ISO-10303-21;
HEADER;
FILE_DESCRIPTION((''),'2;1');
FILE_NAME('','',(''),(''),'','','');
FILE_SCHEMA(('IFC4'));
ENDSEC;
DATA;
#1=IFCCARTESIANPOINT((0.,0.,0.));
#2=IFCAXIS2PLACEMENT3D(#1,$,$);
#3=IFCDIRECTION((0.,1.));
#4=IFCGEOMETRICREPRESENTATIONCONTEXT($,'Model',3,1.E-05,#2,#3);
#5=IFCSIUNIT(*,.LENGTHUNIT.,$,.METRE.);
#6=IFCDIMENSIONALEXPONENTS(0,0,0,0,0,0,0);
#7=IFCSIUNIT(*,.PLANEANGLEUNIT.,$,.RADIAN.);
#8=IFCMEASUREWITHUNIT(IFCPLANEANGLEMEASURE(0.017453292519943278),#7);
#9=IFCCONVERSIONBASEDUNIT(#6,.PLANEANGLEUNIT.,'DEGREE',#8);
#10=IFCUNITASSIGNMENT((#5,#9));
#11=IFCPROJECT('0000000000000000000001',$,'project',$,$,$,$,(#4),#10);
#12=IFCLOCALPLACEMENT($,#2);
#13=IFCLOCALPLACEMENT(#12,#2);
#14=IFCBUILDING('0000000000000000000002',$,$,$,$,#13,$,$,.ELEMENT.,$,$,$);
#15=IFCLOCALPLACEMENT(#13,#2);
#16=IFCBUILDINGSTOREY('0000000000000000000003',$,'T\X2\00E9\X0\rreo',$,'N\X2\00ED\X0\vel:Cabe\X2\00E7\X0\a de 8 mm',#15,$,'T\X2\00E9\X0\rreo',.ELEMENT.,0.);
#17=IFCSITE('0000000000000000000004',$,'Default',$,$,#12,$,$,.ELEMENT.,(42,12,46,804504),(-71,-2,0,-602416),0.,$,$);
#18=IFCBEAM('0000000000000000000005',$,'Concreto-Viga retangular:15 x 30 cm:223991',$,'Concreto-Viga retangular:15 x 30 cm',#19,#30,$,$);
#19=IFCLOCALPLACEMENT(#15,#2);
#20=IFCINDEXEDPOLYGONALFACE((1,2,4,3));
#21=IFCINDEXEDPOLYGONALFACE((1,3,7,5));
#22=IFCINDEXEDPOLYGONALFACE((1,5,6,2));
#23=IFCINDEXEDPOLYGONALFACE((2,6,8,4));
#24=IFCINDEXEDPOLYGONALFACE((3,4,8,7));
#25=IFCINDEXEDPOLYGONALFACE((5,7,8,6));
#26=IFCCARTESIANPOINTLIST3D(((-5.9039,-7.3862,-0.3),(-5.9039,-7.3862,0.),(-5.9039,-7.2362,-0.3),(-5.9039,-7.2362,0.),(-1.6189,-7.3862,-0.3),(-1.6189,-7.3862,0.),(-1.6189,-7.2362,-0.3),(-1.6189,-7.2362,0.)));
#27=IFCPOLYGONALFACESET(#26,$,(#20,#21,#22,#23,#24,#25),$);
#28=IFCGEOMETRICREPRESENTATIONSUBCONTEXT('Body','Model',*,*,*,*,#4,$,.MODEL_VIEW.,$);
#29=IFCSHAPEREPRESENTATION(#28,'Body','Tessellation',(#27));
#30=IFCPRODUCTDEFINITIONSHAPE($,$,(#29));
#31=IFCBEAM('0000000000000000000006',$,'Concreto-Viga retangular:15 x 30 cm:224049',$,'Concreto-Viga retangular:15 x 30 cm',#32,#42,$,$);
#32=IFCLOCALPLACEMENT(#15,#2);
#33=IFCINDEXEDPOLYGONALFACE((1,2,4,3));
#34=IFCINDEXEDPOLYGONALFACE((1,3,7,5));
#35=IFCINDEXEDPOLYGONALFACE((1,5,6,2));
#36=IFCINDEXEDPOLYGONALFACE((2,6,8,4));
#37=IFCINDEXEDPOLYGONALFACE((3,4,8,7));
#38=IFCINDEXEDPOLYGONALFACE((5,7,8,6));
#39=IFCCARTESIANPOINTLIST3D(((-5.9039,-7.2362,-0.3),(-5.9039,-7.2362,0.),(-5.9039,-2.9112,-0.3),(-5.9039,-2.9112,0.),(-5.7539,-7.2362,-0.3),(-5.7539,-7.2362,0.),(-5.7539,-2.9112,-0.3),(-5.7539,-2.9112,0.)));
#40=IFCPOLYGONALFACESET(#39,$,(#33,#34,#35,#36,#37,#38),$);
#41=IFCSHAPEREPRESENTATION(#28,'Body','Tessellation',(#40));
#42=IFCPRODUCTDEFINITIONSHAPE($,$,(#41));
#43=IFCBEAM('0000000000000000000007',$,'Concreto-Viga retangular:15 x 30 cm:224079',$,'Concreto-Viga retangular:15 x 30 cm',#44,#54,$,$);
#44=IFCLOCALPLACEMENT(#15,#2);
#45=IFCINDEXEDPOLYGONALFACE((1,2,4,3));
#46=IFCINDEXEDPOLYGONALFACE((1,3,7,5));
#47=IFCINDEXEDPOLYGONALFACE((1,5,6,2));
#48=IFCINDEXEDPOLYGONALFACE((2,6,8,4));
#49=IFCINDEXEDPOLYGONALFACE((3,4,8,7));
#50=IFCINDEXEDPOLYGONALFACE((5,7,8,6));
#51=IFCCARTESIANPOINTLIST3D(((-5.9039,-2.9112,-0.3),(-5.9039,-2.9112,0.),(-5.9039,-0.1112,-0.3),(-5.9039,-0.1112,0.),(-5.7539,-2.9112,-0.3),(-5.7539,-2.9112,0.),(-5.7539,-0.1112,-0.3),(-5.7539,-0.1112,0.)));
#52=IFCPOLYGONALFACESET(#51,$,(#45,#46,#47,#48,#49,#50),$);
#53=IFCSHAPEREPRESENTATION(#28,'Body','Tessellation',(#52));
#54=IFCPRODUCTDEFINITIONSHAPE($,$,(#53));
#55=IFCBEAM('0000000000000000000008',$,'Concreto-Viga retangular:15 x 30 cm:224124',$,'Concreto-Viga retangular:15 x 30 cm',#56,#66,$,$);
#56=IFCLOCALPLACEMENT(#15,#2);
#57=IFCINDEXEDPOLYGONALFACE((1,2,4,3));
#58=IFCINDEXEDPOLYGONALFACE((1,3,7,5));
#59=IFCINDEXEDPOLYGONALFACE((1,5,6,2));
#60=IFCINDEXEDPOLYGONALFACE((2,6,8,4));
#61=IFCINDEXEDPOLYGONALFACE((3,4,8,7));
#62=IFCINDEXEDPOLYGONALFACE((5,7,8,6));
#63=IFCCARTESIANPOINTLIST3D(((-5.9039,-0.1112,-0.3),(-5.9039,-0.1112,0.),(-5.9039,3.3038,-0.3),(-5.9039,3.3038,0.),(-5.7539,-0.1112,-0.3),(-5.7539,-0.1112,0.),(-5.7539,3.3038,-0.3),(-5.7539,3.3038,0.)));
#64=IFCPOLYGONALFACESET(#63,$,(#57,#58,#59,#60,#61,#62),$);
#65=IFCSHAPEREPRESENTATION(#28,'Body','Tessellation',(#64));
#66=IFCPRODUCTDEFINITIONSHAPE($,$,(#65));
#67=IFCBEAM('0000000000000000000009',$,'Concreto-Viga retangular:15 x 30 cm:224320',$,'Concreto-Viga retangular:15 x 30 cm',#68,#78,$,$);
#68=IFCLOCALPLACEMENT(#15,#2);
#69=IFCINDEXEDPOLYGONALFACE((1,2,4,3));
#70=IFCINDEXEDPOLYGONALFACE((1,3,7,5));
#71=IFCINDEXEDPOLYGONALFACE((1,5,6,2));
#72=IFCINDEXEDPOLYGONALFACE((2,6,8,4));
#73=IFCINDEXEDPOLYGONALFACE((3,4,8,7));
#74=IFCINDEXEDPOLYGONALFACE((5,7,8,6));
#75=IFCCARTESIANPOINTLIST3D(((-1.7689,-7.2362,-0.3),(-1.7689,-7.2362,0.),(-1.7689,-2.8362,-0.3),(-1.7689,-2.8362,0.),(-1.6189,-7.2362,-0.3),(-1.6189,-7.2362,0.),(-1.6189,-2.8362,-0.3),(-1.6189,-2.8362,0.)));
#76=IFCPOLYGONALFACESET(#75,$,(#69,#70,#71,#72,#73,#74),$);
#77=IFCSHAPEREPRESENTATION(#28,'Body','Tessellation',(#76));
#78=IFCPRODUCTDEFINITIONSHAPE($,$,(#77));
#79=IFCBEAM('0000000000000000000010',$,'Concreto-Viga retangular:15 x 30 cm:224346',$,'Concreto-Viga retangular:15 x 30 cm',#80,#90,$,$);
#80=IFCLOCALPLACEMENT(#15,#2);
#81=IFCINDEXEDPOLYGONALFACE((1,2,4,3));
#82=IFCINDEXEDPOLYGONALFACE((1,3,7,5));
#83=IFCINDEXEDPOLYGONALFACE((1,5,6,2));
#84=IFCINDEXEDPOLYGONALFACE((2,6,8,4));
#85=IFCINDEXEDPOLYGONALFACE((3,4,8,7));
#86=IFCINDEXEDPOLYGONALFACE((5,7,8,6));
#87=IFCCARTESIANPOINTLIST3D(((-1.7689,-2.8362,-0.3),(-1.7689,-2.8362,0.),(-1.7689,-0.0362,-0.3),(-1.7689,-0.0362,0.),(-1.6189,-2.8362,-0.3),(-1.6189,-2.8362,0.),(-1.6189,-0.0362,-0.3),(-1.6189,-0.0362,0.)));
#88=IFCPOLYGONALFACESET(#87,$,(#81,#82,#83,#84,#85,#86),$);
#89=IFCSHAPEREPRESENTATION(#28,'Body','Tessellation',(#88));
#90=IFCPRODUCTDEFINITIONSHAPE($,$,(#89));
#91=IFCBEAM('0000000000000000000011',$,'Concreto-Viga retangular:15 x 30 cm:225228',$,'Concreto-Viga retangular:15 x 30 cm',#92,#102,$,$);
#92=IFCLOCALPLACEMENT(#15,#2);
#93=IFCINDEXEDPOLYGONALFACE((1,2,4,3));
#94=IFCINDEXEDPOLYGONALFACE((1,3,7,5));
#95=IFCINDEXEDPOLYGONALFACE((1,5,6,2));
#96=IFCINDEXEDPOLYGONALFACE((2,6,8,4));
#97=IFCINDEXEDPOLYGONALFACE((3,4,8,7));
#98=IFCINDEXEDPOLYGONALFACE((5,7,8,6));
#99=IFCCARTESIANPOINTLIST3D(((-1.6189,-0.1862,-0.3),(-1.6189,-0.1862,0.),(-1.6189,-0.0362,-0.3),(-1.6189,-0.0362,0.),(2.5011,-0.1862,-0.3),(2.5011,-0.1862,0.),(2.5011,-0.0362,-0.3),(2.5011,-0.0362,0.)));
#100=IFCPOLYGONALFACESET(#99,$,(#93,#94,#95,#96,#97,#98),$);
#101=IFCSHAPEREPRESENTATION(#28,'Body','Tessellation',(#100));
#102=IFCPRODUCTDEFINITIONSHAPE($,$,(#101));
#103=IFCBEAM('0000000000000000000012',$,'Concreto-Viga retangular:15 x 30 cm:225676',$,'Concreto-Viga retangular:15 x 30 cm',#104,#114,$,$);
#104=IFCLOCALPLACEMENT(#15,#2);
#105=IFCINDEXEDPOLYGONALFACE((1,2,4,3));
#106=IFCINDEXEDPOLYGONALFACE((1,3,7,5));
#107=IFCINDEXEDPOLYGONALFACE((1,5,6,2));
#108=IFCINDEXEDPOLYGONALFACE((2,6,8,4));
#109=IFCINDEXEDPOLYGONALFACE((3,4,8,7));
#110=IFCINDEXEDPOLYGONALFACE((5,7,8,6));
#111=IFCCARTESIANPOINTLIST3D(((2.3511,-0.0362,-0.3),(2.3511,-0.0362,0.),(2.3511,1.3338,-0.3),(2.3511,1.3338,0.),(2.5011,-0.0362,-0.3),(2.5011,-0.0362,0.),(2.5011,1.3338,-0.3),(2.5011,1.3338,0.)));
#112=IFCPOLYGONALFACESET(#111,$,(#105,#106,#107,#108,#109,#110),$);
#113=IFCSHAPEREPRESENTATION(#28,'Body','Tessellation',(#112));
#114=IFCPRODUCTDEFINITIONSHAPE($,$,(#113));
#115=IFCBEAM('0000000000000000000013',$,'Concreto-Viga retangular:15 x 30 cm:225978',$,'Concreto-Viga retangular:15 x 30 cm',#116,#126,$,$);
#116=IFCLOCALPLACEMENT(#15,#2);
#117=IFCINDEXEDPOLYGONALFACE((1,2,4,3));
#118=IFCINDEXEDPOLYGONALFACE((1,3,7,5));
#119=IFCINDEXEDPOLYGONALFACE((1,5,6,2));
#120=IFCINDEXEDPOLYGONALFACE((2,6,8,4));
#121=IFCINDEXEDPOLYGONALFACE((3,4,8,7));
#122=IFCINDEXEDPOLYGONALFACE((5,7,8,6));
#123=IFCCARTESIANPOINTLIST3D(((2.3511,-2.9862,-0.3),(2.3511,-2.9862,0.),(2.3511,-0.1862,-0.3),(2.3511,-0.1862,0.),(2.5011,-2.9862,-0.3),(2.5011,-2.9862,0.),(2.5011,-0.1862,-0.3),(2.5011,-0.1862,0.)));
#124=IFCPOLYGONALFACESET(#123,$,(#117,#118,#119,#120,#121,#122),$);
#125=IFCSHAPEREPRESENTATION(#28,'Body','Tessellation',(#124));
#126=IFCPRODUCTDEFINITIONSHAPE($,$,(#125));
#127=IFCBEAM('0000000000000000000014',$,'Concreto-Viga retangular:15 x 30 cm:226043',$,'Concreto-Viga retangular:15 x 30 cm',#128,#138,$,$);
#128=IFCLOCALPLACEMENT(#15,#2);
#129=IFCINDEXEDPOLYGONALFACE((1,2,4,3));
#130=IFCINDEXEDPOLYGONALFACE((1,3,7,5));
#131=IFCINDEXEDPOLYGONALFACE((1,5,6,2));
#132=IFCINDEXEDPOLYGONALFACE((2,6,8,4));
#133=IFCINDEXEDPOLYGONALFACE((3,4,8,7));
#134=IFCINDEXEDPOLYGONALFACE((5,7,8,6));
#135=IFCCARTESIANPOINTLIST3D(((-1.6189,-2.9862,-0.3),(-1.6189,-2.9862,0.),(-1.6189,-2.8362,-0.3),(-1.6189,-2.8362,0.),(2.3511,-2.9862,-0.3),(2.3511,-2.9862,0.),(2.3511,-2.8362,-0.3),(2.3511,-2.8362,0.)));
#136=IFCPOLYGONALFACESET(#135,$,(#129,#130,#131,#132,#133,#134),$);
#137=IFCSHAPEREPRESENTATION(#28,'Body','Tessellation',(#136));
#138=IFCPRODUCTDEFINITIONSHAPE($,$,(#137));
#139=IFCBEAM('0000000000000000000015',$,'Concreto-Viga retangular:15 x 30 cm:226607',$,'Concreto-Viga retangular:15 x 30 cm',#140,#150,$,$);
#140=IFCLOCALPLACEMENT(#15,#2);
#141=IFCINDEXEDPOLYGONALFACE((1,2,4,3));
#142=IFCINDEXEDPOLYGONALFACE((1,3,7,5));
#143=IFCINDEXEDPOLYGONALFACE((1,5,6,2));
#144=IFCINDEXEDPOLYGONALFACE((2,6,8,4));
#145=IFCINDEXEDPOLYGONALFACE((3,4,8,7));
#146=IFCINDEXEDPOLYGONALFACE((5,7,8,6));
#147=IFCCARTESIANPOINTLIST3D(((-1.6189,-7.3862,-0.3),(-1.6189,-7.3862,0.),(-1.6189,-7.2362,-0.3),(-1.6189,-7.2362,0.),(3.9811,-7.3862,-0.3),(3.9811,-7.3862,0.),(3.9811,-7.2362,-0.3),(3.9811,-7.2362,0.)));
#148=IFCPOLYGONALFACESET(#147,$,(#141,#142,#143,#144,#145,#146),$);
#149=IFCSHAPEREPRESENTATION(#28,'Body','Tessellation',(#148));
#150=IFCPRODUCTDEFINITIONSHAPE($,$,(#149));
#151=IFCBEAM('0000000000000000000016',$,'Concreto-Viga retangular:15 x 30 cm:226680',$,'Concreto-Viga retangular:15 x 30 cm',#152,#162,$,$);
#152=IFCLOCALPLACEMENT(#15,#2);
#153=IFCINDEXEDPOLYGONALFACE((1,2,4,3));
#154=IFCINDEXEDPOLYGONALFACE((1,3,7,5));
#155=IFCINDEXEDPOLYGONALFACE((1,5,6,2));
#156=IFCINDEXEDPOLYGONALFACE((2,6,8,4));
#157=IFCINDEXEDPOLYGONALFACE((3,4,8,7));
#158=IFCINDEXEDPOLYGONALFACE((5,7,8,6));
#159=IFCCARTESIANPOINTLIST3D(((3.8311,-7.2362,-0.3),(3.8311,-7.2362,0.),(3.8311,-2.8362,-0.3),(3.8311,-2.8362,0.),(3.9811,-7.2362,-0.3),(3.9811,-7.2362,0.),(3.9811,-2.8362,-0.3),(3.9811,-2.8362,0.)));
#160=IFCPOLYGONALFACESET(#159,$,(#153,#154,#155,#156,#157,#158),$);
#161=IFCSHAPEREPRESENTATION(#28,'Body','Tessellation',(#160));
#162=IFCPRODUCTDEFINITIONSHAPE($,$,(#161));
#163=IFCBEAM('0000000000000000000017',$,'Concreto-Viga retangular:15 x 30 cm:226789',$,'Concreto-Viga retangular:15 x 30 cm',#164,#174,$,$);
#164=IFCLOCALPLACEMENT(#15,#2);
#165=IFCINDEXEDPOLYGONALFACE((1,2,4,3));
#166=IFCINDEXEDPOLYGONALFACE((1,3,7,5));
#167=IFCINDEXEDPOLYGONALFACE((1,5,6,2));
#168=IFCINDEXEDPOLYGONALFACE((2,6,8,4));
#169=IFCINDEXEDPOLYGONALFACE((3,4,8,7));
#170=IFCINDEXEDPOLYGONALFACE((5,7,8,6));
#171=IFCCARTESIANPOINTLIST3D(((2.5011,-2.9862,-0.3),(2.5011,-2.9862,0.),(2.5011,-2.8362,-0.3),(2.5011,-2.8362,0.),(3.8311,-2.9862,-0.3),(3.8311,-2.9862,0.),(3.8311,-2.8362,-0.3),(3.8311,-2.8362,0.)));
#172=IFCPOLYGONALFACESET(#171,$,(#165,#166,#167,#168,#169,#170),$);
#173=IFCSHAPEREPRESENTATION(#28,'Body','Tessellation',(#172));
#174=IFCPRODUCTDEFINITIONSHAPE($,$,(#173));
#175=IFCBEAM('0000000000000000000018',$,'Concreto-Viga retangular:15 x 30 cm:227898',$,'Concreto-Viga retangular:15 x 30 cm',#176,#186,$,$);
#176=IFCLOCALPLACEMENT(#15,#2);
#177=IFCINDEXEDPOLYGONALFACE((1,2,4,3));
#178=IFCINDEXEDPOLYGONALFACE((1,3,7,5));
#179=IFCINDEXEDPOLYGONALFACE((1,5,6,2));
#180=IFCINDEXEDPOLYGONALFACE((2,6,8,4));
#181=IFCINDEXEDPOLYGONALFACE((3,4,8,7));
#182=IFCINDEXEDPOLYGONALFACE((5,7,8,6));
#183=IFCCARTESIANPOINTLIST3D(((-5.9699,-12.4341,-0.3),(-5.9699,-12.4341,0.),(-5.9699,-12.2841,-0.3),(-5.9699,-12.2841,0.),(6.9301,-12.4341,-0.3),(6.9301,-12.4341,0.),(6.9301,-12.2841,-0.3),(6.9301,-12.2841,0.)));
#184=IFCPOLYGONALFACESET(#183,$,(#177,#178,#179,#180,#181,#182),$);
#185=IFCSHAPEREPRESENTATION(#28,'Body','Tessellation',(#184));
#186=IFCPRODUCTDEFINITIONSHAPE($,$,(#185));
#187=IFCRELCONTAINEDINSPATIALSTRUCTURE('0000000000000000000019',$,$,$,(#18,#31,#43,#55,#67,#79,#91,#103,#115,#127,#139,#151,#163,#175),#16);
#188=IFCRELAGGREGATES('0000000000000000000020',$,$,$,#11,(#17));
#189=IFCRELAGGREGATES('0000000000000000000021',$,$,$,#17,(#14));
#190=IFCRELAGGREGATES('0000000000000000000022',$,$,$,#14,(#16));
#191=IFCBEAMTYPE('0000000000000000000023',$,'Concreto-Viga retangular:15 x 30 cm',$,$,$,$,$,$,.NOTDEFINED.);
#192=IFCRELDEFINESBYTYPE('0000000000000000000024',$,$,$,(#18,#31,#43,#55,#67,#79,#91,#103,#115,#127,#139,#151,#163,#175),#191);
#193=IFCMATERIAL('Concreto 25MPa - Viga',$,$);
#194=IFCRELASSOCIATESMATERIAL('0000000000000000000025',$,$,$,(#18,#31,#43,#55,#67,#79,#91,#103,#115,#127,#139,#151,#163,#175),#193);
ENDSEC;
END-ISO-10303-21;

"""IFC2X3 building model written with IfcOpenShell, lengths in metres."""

from ifc_helpers import new_model, entity, si_unit, converted_unit, direction, frame, frame_2d, origin, place, context, subcontext, project, spatial, rectangle, extrude, material, type_object, element, save


model = new_model("IFC2X3")

# Units and contexts
model_context = context("Model", 3, precision=1e-05, world=origin(), true_north=direction((0.0, 1.0)))
body_context = subcontext(model_context, "Body", "Model", "MODEL_VIEW")
ifc_project = project(units=[si_unit("LENGTHUNIT", "METRE"), converted_unit("PLANEANGLEUNIT", "DEGREE", entity("IfcPlaneAngleMeasure", 0.017453292519943278), si_unit("PLANEANGLEUNIT", "RADIAN"), dimensions=[0, 0, 0, 0, 0, 0, 0])], contexts=[model_context])

# Site, building, storey
site_placement = place(None, origin())
site = spatial("IfcSite", under=ifc_project, at=site_placement, Name="Default", CompositionType="ELEMENT", RefLatitude=(42, 12, 46, 804504), RefLongitude=(-71, -2, 0, -602416), RefElevation=0.0)
building_placement = place(site_placement, origin())
building = spatial("IfcBuilding", under=site, at=building_placement, CompositionType="ELEMENT")
storey_placement = place(building_placement, origin())
storey = spatial("IfcBuildingStorey", under=building, at=storey_placement, Name="Térreo", ObjectType="Nível:Cabeça de 8 mm", LongName="Térreo", CompositionType="ELEMENT", Elevation=0.0)

# Beams
ifc_material_1 = material(Name="Concreto 25MPa - Viga")
beam_type = type_object("IfcBeamType", Name="Concreto-Viga retangular:15 x 30 cm", PredefinedType="NOTDEFINED")
beam_1_placement = place(storey_placement, frame((-5.8289, -7.3112, 0.0)))
element("IfcBeam", 1, at=beam_1_placement, inside=storey, type_object=beam_type, material=ifc_material_1, Name="Concreto-Viga retangular:15 x 30 cm:223991", ObjectType="Concreto-Viga retangular:15 x 30 cm", context=body_context, shape_type="SweptSolid", body=[
    extrude(rectangle(XDim=0.3, YDim=0.15, at=frame_2d((0.0, 0.0), x_axis=(1.0, 0.0))), frame((-0.075, 0.0, -0.15), z_axis=(1.0, 0.0, 0.0), x_axis=(0.0, 0.0, -1.0)), (0.0, 0.0, 1.0), 4.285),
])
beam_2_placement = place(storey_placement, frame((-5.8289, -7.3112, 0.0), z_axis=(0.0, 0.0, 1.0), x_axis=(0.0, 1.0, 0.0)))
element("IfcBeam", 2, at=beam_2_placement, inside=storey, type_object=beam_type, material=ifc_material_1, Name="Concreto-Viga retangular:15 x 30 cm:224049", ObjectType="Concreto-Viga retangular:15 x 30 cm", context=body_context, shape_type="SweptSolid", body=[
    extrude(rectangle(XDim=0.3, YDim=0.15, at=frame_2d((0.0, 0.0), x_axis=(1.0, 0.0))), frame((0.075, 0.0, -0.15), z_axis=(1.0, 0.0, 0.0), x_axis=(0.0, 0.0, -1.0)), (0.0, 0.0, 1.0), 4.325),
])
beam_3_placement = place(storey_placement, frame((-5.8289, -2.9112, 0.0), z_axis=(0.0, 0.0, 1.0), x_axis=(0.0, 1.0, 0.0)))
element("IfcBeam", 3, at=beam_3_placement, inside=storey, type_object=beam_type, material=ifc_material_1, Name="Concreto-Viga retangular:15 x 30 cm:224079", ObjectType="Concreto-Viga retangular:15 x 30 cm", context=body_context, shape_type="SweptSolid", body=[
    extrude(rectangle(XDim=0.3, YDim=0.15, at=frame_2d((0.0, 0.0), x_axis=(1.0, 0.0))), frame((0.0, 0.0, -0.15), z_axis=(1.0, 0.0, 0.0), x_axis=(0.0, 0.0, -1.0)), (0.0, 0.0, 1.0), 2.8),
])
beam_4_placement = place(storey_placement, frame((-5.8289, -0.1112, 0.0), z_axis=(0.0, 0.0, 1.0), x_axis=(0.0, 1.0, 0.0)))
element("IfcBeam", 4, at=beam_4_placement, inside=storey, type_object=beam_type, material=ifc_material_1, Name="Concreto-Viga retangular:15 x 30 cm:224124", ObjectType="Concreto-Viga retangular:15 x 30 cm", context=body_context, shape_type="SweptSolid", body=[
    extrude(rectangle(XDim=0.3, YDim=0.15, at=frame_2d((0.0, 0.0), x_axis=(1.0, 0.0))), frame((0.0, 0.0, -0.15), z_axis=(1.0, 0.0, 0.0), x_axis=(0.0, 0.0, -1.0)), (0.0, 0.0, 1.0), 3.415),
])
beam_5_placement = place(storey_placement, frame((-1.6939, -7.3112, 0.0), z_axis=(0.0, 0.0, 1.0), x_axis=(0.0, 1.0, 0.0)))
element("IfcBeam", 5, at=beam_5_placement, inside=storey, type_object=beam_type, material=ifc_material_1, Name="Concreto-Viga retangular:15 x 30 cm:224320", ObjectType="Concreto-Viga retangular:15 x 30 cm", context=body_context, shape_type="SweptSolid", body=[
    extrude(rectangle(XDim=0.3, YDim=0.15, at=frame_2d((0.0, 0.0), x_axis=(1.0, 0.0))), frame((0.075, 0.0, -0.15), z_axis=(1.0, 0.0, 0.0), x_axis=(0.0, 0.0, -1.0)), (0.0, 0.0, 1.0), 4.4),
])
beam_6_placement = place(storey_placement, frame((-1.6939, -2.9112, 0.0), z_axis=(0.0, 0.0, 1.0), x_axis=(0.0, 1.0, 0.0)))
element("IfcBeam", 6, at=beam_6_placement, inside=storey, type_object=beam_type, material=ifc_material_1, Name="Concreto-Viga retangular:15 x 30 cm:224346", ObjectType="Concreto-Viga retangular:15 x 30 cm", context=body_context, shape_type="SweptSolid", body=[
    extrude(rectangle(XDim=0.3, YDim=0.15, at=frame_2d((0.0, 0.0), x_axis=(1.0, 0.0))), frame((0.075, 0.0, -0.15), z_axis=(1.0, 0.0, 0.0), x_axis=(0.0, 0.0, -1.0)), (0.0, 0.0, 1.0), 2.8),
])
beam_7_placement = place(storey_placement, frame((-1.6939, -0.1112, 0.0)))
element("IfcBeam", 7, at=beam_7_placement, inside=storey, type_object=beam_type, material=ifc_material_1, Name="Concreto-Viga retangular:15 x 30 cm:225228", ObjectType="Concreto-Viga retangular:15 x 30 cm", context=body_context, shape_type="SweptSolid", body=[
    extrude(rectangle(XDim=0.3, YDim=0.15, at=frame_2d((0.0, 0.0), x_axis=(1.0, 0.0))), frame((0.075, 0.0, -0.15), z_axis=(1.0, 0.0, 0.0), x_axis=(0.0, 0.0, -1.0)), (0.0, 0.0, 1.0), 4.12),
])
beam_8_placement = place(storey_placement, frame((2.4261, -0.1112, 0.0), z_axis=(0.0, 0.0, 1.0), x_axis=(0.0, 1.0, 0.0)))
element("IfcBeam", 8, at=beam_8_placement, inside=storey, type_object=beam_type, material=ifc_material_1, Name="Concreto-Viga retangular:15 x 30 cm:225676", ObjectType="Concreto-Viga retangular:15 x 30 cm", context=body_context, shape_type="SweptSolid", body=[
    extrude(rectangle(XDim=0.3, YDim=0.15, at=frame_2d((0.0, 0.0), x_axis=(1.0, 0.0))), frame((0.075, 0.0, -0.15), z_axis=(1.0, 0.0, 0.0), x_axis=(0.0, 0.0, -1.0)), (0.0, 0.0, 1.0), 1.37),
])
beam_9_placement = place(storey_placement, frame((2.4261, -0.1112, 0.0), z_axis=(0.0, 0.0, 1.0), x_axis=(0.0, -1.0, 0.0)))
element("IfcBeam", 9, at=beam_9_placement, inside=storey, type_object=beam_type, material=ifc_material_1, Name="Concreto-Viga retangular:15 x 30 cm:225978", ObjectType="Concreto-Viga retangular:15 x 30 cm", context=body_context, shape_type="SweptSolid", body=[
    extrude(rectangle(XDim=0.3, YDim=0.15, at=frame_2d((0.0, 0.0), x_axis=(1.0, 0.0))), frame((0.075, 0.0, -0.15), z_axis=(1.0, 0.0, 0.0), x_axis=(0.0, 0.0, -1.0)), (0.0, 0.0, 1.0), 2.8),
])
beam_10_placement = place(storey_placement, frame((-1.6939, -2.9112, 0.0)))
element("IfcBeam", 10, at=beam_10_placement, inside=storey, type_object=beam_type, material=ifc_material_1, Name="Concreto-Viga retangular:15 x 30 cm:226043", ObjectType="Concreto-Viga retangular:15 x 30 cm", context=body_context, shape_type="SweptSolid", body=[
    extrude(rectangle(XDim=0.3, YDim=0.15, at=frame_2d((0.0, 0.0), x_axis=(1.0, 0.0))), frame((0.075, 0.0, -0.15), z_axis=(1.0, 0.0, 0.0), x_axis=(0.0, 0.0, -1.0)), (0.0, 0.0, 1.0), 3.97),
])
beam_11_placement = place(storey_placement, frame((-1.6939, -7.3112, 0.0)))
element("IfcBeam", 11, at=beam_11_placement, inside=storey, type_object=beam_type, material=ifc_material_1, Name="Concreto-Viga retangular:15 x 30 cm:226607", ObjectType="Concreto-Viga retangular:15 x 30 cm", context=body_context, shape_type="SweptSolid", body=[
    extrude(rectangle(XDim=0.3, YDim=0.15, at=frame_2d((0.0, 0.0), x_axis=(1.0, 0.0))), frame((0.075, 0.0, -0.15), z_axis=(1.0, 0.0, 0.0), x_axis=(0.0, 0.0, -1.0)), (0.0, 0.0, 1.0), 5.6),
])
beam_12_placement = place(storey_placement, frame((3.9061, -7.3112, 0.0), z_axis=(0.0, 0.0, 1.0), x_axis=(0.0, 1.0, 0.0)))
element("IfcBeam", 12, at=beam_12_placement, inside=storey, type_object=beam_type, material=ifc_material_1, Name="Concreto-Viga retangular:15 x 30 cm:226680", ObjectType="Concreto-Viga retangular:15 x 30 cm", context=body_context, shape_type="SweptSolid", body=[
    extrude(rectangle(XDim=0.3, YDim=0.15, at=frame_2d((0.0, 0.0), x_axis=(1.0, 0.0))), frame((0.075, 0.0, -0.15), z_axis=(1.0, 0.0, 0.0), x_axis=(0.0, 0.0, -1.0)), (0.0, 0.0, 1.0), 4.4),
])
beam_13_placement = place(storey_placement, frame((2.4261, -2.9112, 0.0)))
element("IfcBeam", 13, at=beam_13_placement, inside=storey, type_object=beam_type, material=ifc_material_1, Name="Concreto-Viga retangular:15 x 30 cm:226789", ObjectType="Concreto-Viga retangular:15 x 30 cm", context=body_context, shape_type="SweptSolid", body=[
    extrude(rectangle(XDim=0.3, YDim=0.15, at=frame_2d((0.0, 0.0), x_axis=(1.0, 0.0))), frame((0.075, 0.0, -0.15), z_axis=(1.0, 0.0, 0.0), x_axis=(0.0, 0.0, -1.0)), (0.0, 0.0, 1.0), 1.33),
])
beam_14_placement = place(storey_placement, frame((-5.9699, -12.3591, 0.0)))
element("IfcBeam", 14, at=beam_14_placement, inside=storey, type_object=beam_type, material=ifc_material_1, Name="Concreto-Viga retangular:15 x 30 cm:227898", ObjectType="Concreto-Viga retangular:15 x 30 cm", context=body_context, shape_type="SweptSolid", body=[
    extrude(rectangle(XDim=0.3, YDim=0.15, at=frame_2d((0.0, 0.0), x_axis=(1.0, 0.0))), frame((0.0, 0.0, -0.15), z_axis=(1.0, 0.0, 0.0), x_axis=(0.0, 0.0, -1.0)), (0.0, 0.0, 1.0), 12.9),
])

save(model, "model.ifc")
